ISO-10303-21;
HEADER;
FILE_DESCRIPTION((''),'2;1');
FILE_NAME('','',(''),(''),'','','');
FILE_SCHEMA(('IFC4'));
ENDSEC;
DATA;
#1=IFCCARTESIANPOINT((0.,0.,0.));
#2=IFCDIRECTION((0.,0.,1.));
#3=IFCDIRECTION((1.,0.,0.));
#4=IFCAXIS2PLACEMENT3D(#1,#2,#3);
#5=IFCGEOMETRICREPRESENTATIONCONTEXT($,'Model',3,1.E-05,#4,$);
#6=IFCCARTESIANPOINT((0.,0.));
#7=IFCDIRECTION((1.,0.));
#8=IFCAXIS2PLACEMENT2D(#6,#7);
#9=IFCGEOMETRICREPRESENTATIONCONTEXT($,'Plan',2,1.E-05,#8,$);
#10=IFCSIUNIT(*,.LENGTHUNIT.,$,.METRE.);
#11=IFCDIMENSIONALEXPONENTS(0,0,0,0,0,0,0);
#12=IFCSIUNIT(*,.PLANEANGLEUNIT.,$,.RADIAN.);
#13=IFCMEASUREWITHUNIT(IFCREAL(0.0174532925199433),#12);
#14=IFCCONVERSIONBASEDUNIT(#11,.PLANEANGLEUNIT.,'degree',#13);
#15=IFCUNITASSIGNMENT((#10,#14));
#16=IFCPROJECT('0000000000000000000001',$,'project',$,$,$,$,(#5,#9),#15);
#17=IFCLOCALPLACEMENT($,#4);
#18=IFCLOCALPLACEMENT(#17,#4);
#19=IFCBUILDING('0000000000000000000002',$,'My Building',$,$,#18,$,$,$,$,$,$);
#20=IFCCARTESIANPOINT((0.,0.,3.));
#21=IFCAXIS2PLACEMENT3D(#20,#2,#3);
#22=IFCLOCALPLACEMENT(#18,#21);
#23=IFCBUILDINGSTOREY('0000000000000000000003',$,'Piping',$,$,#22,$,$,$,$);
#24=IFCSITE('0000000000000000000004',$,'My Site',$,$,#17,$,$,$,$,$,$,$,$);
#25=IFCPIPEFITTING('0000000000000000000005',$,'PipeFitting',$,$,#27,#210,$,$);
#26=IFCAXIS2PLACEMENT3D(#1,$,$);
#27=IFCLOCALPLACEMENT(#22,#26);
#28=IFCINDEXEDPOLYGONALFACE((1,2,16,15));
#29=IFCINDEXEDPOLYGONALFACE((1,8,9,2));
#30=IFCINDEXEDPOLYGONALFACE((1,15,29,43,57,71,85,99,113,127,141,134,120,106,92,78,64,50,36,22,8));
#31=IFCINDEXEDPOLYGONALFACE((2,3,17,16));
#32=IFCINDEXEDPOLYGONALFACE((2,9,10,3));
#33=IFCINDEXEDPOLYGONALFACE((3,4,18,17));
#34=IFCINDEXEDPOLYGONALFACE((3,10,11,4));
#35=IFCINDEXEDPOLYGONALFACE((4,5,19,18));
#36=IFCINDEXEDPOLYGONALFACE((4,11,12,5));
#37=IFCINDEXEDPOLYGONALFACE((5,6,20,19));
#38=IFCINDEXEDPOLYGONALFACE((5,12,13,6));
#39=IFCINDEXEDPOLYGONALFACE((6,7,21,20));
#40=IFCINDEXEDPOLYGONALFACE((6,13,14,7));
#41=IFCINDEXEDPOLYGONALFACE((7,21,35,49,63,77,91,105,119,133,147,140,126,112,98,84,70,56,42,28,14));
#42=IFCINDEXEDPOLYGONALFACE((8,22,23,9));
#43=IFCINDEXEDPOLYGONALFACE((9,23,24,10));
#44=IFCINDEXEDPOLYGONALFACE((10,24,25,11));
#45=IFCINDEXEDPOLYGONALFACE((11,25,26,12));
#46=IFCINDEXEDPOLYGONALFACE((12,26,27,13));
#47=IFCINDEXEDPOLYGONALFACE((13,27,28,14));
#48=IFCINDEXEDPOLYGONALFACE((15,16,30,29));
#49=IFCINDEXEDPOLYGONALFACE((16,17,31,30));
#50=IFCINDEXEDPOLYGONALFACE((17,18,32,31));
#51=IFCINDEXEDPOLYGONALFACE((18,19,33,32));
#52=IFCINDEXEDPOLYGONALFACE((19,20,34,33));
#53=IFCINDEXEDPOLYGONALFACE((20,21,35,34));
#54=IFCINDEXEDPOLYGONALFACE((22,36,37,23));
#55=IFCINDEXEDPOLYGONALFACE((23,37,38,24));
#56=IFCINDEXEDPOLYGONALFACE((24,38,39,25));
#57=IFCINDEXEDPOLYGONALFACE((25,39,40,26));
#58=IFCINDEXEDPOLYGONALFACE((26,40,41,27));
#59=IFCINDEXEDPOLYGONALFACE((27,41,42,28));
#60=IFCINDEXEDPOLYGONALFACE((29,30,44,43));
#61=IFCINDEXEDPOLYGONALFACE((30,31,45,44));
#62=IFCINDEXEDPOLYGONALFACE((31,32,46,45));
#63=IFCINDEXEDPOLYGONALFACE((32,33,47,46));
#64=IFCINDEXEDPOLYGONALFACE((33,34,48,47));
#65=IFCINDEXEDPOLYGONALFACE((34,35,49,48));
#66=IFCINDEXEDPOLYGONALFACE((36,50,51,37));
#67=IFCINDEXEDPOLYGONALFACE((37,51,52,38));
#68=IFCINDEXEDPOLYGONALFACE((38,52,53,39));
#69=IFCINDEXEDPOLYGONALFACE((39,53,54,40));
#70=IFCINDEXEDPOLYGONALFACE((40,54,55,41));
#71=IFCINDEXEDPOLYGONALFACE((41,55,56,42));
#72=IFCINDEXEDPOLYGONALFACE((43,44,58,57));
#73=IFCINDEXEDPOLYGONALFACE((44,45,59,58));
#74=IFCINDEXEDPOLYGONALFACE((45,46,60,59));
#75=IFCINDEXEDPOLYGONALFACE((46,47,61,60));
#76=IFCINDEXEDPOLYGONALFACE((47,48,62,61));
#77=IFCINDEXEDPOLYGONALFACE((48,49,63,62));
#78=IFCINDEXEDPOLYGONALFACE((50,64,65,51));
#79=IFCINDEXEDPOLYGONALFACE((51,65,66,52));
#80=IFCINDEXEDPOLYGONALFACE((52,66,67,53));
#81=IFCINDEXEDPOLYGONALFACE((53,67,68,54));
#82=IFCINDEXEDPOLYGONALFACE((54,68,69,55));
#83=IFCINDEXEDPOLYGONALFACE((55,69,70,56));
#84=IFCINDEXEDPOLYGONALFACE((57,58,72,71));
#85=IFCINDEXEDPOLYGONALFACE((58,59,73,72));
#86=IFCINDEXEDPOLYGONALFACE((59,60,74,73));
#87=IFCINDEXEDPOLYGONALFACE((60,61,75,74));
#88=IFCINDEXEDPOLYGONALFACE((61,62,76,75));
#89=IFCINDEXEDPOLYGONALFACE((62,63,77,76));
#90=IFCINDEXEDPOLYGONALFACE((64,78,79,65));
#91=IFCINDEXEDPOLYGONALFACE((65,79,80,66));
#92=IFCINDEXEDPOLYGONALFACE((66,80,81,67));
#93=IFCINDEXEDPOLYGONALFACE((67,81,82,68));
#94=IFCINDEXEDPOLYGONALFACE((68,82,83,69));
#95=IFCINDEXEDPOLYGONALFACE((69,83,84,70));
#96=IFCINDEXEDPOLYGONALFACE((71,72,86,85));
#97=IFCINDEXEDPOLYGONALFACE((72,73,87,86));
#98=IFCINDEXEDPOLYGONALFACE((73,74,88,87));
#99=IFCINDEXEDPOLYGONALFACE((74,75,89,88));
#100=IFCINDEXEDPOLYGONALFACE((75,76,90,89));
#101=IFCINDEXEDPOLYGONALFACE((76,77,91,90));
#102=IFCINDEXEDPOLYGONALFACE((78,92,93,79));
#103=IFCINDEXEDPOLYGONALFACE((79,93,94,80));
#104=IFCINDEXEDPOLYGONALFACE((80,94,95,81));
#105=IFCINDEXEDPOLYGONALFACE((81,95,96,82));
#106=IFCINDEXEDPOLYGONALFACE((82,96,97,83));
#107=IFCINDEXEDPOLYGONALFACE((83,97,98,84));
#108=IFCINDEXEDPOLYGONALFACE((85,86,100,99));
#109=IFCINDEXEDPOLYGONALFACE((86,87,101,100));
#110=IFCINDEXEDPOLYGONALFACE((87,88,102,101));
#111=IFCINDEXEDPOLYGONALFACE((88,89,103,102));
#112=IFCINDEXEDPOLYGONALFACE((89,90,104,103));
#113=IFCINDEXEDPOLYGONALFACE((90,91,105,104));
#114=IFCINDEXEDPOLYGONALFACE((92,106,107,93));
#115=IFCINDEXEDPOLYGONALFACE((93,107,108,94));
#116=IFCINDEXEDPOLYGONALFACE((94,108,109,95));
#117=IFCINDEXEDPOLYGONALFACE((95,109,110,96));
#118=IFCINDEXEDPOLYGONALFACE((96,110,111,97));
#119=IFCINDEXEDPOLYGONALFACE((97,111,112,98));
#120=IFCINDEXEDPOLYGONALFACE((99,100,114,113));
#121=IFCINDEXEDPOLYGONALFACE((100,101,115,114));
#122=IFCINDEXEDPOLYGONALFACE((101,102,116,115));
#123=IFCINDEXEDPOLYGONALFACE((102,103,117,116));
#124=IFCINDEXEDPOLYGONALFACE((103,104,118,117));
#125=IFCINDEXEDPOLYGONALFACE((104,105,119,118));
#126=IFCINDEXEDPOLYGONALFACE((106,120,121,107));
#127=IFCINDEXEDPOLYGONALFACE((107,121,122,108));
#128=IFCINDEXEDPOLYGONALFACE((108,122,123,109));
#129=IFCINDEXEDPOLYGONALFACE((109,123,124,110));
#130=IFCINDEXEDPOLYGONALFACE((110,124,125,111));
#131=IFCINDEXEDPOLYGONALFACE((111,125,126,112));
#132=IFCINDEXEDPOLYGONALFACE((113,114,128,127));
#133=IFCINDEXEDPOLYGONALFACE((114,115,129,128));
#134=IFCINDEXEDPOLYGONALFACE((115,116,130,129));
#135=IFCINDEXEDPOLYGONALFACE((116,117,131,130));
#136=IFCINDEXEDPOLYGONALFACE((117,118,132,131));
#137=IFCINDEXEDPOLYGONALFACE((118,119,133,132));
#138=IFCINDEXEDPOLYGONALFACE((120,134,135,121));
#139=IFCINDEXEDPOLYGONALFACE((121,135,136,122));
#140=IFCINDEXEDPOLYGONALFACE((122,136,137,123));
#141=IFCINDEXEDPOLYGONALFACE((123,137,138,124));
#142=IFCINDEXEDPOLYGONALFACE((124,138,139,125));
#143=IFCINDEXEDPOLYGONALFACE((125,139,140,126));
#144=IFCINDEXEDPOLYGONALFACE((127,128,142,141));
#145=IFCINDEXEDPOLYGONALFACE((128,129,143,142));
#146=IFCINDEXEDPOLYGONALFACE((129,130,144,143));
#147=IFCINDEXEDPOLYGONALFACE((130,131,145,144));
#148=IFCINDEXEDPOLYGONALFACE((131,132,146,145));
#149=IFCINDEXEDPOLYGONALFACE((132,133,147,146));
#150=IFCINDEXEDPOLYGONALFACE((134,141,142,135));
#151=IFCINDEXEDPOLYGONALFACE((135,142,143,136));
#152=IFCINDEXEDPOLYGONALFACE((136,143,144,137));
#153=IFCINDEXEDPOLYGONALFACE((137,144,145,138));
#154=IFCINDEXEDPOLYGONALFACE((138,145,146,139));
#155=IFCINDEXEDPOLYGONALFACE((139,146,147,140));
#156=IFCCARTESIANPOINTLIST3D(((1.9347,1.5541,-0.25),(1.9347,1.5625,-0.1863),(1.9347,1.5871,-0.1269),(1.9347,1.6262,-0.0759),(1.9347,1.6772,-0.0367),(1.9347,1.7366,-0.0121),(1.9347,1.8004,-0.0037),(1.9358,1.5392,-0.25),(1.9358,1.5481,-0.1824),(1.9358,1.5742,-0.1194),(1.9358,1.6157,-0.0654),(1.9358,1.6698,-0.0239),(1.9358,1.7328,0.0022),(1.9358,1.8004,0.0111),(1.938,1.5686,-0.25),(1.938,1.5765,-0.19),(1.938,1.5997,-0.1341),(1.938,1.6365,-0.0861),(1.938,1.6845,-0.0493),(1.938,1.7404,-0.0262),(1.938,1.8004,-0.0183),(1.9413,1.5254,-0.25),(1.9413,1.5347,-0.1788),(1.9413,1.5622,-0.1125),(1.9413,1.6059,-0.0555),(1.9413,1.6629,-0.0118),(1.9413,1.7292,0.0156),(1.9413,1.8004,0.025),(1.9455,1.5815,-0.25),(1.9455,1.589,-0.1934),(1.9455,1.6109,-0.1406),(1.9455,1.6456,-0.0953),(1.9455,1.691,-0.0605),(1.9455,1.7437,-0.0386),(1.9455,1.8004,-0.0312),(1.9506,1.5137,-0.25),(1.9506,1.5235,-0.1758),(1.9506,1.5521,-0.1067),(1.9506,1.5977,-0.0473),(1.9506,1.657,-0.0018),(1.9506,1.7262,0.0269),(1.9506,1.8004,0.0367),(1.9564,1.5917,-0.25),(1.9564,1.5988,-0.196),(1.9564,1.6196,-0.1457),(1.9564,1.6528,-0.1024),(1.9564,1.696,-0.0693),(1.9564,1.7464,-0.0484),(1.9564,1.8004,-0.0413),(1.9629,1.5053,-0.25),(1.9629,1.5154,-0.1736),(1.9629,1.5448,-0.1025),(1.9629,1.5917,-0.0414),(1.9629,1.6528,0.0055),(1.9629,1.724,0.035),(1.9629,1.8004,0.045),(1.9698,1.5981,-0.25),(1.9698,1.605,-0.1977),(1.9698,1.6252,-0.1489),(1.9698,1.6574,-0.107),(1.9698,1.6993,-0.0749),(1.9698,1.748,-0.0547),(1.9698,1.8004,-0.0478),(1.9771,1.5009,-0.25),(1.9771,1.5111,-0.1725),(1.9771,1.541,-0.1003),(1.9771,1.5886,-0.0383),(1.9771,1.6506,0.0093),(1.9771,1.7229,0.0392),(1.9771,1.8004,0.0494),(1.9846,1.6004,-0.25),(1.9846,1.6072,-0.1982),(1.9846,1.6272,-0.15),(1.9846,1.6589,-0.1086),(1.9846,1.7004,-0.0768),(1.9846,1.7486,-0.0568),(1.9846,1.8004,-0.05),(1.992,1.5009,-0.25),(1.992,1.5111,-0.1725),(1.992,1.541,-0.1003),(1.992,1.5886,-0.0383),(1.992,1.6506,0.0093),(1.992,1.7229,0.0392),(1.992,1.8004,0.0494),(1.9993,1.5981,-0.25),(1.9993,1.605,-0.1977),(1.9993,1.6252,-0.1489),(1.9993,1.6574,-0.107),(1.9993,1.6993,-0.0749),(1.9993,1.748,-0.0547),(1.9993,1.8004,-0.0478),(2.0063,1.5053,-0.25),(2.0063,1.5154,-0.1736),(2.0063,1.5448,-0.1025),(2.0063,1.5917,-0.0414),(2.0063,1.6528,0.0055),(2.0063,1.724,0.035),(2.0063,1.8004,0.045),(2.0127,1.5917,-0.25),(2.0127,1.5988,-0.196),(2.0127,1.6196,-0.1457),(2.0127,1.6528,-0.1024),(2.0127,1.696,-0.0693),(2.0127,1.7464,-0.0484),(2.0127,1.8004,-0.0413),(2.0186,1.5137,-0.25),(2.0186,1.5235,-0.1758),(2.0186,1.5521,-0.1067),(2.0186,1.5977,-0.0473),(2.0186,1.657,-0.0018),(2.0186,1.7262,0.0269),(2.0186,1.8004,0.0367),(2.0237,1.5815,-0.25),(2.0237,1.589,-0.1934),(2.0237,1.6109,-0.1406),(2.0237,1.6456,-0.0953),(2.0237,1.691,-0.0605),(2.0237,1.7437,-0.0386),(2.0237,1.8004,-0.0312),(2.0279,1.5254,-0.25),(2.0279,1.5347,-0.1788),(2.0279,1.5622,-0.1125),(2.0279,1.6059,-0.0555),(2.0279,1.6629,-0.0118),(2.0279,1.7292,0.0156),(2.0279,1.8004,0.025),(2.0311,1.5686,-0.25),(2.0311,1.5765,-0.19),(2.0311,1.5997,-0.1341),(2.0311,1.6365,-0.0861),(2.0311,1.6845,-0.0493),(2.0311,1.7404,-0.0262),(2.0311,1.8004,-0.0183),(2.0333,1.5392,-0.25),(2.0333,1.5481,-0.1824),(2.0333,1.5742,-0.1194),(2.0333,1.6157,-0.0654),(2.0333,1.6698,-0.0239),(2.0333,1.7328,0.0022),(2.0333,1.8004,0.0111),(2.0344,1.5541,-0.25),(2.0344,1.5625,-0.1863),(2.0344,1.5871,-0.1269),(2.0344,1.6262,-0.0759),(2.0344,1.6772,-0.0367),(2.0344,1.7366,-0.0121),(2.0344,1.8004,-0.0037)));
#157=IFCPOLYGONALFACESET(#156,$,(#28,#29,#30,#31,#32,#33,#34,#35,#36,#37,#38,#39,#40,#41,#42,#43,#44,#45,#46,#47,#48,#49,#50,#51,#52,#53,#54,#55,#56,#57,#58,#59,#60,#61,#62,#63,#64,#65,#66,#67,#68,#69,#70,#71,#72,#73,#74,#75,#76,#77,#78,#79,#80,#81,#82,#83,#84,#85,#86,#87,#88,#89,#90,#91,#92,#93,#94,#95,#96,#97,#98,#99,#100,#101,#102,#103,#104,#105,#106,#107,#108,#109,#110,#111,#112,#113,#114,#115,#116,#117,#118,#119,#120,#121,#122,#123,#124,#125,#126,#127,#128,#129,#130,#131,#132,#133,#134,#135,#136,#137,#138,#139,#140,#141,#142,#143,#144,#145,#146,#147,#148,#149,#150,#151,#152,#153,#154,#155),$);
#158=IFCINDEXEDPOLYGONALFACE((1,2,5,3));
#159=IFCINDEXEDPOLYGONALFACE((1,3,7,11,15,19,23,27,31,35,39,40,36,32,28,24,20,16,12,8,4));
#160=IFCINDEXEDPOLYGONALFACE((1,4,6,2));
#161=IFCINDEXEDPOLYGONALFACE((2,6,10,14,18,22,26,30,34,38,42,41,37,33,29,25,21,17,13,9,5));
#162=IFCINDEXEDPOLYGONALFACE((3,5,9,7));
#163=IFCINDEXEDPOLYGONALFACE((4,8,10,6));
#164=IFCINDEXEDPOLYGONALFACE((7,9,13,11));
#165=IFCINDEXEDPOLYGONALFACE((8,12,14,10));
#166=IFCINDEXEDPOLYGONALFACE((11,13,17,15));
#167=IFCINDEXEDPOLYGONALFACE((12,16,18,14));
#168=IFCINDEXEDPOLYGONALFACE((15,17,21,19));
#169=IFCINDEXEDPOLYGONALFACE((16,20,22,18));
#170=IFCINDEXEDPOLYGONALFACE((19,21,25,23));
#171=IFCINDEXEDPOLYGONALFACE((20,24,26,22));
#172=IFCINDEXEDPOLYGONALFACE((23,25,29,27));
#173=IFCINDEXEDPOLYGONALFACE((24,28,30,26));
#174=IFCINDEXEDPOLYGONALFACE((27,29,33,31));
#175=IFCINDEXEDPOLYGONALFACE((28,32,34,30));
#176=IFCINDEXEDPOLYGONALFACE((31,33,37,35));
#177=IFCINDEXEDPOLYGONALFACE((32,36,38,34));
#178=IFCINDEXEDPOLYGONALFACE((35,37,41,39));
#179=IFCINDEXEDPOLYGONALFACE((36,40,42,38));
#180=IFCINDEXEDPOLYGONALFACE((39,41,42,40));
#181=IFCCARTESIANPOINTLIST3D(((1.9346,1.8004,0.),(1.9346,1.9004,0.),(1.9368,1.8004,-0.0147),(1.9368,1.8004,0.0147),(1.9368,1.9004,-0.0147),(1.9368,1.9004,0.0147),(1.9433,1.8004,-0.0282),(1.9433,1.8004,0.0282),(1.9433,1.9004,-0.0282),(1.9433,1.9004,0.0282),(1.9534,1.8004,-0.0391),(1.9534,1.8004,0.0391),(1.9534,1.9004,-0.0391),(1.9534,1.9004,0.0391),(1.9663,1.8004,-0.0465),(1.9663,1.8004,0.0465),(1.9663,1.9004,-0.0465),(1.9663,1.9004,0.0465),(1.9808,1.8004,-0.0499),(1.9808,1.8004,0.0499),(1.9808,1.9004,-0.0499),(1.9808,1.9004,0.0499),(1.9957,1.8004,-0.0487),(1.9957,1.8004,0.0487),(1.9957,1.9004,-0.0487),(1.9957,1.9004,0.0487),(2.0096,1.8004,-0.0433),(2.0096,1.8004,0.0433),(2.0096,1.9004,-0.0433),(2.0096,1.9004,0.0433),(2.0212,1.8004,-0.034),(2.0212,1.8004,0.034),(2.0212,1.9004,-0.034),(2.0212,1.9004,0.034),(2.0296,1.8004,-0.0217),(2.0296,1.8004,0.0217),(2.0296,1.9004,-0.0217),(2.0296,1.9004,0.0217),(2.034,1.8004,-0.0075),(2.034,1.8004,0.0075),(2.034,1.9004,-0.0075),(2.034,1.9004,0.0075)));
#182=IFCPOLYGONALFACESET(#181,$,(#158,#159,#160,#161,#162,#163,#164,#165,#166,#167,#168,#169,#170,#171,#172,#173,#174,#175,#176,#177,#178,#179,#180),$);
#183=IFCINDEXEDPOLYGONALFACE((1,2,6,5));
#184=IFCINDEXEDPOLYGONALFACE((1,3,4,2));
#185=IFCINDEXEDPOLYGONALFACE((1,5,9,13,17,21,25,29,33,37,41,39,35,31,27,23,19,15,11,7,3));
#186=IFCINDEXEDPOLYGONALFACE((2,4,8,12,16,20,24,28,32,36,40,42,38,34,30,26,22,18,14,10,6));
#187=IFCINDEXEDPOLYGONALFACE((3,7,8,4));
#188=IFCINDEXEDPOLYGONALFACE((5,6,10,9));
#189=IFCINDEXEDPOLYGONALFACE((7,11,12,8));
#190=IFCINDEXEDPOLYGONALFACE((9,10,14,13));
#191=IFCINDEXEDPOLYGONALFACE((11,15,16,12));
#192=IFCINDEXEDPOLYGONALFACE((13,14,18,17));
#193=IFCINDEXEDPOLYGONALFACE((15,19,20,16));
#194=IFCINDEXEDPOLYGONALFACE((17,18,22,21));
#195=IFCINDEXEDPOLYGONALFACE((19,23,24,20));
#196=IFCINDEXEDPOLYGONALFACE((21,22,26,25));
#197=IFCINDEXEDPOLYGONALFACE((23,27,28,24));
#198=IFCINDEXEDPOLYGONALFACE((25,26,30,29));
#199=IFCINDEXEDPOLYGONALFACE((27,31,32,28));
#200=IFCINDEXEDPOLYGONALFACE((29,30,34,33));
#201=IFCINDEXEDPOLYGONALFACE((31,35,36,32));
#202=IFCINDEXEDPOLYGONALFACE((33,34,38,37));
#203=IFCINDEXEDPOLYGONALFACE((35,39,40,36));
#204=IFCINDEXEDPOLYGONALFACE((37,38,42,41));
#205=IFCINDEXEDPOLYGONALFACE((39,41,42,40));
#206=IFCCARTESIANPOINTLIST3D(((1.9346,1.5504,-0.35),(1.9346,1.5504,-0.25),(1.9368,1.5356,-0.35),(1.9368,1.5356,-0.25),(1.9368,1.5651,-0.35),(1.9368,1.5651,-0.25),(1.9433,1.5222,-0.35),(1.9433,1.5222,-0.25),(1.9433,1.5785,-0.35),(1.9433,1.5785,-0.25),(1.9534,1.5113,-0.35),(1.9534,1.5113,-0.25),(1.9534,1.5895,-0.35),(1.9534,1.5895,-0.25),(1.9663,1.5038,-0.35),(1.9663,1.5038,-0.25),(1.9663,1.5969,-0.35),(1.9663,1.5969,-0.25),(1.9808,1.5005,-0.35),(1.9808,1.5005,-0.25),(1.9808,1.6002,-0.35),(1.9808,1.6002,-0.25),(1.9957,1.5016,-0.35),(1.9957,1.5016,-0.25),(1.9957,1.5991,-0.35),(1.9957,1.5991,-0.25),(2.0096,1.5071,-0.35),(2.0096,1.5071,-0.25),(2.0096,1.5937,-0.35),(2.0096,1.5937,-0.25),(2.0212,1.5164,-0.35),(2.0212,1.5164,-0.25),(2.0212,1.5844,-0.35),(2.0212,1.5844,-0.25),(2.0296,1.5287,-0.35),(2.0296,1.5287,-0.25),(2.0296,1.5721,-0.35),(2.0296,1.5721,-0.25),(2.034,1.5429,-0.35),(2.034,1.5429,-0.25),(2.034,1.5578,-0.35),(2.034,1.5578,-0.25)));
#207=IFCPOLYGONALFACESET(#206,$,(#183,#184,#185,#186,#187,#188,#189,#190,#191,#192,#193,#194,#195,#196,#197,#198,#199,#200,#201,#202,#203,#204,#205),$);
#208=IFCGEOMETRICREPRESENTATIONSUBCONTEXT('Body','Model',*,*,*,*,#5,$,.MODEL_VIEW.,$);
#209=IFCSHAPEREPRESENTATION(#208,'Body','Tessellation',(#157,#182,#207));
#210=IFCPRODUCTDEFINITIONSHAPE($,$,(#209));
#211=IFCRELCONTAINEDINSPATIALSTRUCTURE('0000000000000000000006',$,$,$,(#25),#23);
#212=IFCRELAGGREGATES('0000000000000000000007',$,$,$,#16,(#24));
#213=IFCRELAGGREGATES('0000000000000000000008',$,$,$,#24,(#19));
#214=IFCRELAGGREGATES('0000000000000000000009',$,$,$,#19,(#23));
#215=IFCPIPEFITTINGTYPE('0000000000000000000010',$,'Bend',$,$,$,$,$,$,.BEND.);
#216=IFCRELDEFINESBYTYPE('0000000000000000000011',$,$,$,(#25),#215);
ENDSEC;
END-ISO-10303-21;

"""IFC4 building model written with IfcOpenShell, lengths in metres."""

from ifc_helpers import new_model, entity, si_unit, converted_unit, frame, origin_with_axes, origin_2d_with_axis, place, context, subcontext, project, spatial, circle, extrude, source, transform, mapped, type_object, type_shapes, element, save


model = new_model("IFC4")

# Units and contexts
model_context = context("Model", 3, precision=1e-05, world=origin_with_axes())
plan_context = context("Plan", 2, precision=1e-05, world=origin_2d_with_axis())
body_context = subcontext(model_context, "Body", "Model", "MODEL_VIEW")
ifc_project = project(units=[si_unit("LENGTHUNIT", "METRE"), converted_unit("PLANEANGLEUNIT", "degree", entity("IfcReal", 0.0174532925199433), si_unit("PLANEANGLEUNIT", "RADIAN"), dimensions=[0, 0, 0, 0, 0, 0, 0])], contexts=[model_context, plan_context])

# Site, building, storey
site_placement = place(None, origin_with_axes())
site = spatial("IfcSite", under=ifc_project, at=site_placement, Name="My Site")
building_placement = place(site_placement, origin_with_axes())
building = spatial("IfcBuilding", under=site, at=building_placement, Name="My Building")
storey_placement = place(building_placement, frame((0.0, 0.0, 3.0), z_axis=(0.0, 0.0, 1.0), x_axis=(1.0, 0.0, 0.0)))
storey = spatial("IfcBuildingStorey", under=building, at=storey_placement, Name="Piping")

# Pipe fitting
pipe_fitting_type = type_object("IfcPipeFittingType", Name="Bend", PredefinedType="BEND")
shared_shape = source(origin_with_axes(), body_context, "Body", "SolidModel", [
    entity("IfcSweptDiskSolid", entity("IfcIndexedPolyCurve", entity("IfcCartesianPointList3D", [[0.0, 0.0, -0.1], [0.0, -0.0732, -0.2768], [0.0, -0.25, -0.35]]), [entity("IfcArcIndex", [1, 2, 3])]), 0.05),
    extrude(circle(Radius=0.05), origin_with_axes(), (0.0, 0.0, -1.0), 0.1),
    extrude(circle(Radius=0.05), frame((0.0, -0.25, -0.35), z_axis=(0.0, -1.0, 0.0), x_axis=(1.0, 0.0, 0.0)), (0.0, 0.0, 1.0), 0.1),
])
type_shapes(pipe_fitting_type, [shared_shape])
for number, where, z_axis, x_axis, name in (
    (1, (1.9846, 1.9004, 0.0), (0.0, 1.0, 0.0), (-1.0, 0.0, 0.0), "PipeFitting"),
):
    element("IfcPipeFitting", number, at=place(storey_placement, frame(where, z_axis=z_axis, x_axis=x_axis)), inside=storey, type_object=pipe_fitting_type, Name=name, context=body_context, shape_type="MappedRepresentation", body=[
        mapped(shared_shape, transform((0.0, 0.0, 0.0), x_axis=(1.0, 0.0, 0.0), y_axis=(0.0, 1.0, 0.0), z_axis=(0.0, 0.0, 1.0), scale=1.0)),
    ])

save(model, "model.ifc")
